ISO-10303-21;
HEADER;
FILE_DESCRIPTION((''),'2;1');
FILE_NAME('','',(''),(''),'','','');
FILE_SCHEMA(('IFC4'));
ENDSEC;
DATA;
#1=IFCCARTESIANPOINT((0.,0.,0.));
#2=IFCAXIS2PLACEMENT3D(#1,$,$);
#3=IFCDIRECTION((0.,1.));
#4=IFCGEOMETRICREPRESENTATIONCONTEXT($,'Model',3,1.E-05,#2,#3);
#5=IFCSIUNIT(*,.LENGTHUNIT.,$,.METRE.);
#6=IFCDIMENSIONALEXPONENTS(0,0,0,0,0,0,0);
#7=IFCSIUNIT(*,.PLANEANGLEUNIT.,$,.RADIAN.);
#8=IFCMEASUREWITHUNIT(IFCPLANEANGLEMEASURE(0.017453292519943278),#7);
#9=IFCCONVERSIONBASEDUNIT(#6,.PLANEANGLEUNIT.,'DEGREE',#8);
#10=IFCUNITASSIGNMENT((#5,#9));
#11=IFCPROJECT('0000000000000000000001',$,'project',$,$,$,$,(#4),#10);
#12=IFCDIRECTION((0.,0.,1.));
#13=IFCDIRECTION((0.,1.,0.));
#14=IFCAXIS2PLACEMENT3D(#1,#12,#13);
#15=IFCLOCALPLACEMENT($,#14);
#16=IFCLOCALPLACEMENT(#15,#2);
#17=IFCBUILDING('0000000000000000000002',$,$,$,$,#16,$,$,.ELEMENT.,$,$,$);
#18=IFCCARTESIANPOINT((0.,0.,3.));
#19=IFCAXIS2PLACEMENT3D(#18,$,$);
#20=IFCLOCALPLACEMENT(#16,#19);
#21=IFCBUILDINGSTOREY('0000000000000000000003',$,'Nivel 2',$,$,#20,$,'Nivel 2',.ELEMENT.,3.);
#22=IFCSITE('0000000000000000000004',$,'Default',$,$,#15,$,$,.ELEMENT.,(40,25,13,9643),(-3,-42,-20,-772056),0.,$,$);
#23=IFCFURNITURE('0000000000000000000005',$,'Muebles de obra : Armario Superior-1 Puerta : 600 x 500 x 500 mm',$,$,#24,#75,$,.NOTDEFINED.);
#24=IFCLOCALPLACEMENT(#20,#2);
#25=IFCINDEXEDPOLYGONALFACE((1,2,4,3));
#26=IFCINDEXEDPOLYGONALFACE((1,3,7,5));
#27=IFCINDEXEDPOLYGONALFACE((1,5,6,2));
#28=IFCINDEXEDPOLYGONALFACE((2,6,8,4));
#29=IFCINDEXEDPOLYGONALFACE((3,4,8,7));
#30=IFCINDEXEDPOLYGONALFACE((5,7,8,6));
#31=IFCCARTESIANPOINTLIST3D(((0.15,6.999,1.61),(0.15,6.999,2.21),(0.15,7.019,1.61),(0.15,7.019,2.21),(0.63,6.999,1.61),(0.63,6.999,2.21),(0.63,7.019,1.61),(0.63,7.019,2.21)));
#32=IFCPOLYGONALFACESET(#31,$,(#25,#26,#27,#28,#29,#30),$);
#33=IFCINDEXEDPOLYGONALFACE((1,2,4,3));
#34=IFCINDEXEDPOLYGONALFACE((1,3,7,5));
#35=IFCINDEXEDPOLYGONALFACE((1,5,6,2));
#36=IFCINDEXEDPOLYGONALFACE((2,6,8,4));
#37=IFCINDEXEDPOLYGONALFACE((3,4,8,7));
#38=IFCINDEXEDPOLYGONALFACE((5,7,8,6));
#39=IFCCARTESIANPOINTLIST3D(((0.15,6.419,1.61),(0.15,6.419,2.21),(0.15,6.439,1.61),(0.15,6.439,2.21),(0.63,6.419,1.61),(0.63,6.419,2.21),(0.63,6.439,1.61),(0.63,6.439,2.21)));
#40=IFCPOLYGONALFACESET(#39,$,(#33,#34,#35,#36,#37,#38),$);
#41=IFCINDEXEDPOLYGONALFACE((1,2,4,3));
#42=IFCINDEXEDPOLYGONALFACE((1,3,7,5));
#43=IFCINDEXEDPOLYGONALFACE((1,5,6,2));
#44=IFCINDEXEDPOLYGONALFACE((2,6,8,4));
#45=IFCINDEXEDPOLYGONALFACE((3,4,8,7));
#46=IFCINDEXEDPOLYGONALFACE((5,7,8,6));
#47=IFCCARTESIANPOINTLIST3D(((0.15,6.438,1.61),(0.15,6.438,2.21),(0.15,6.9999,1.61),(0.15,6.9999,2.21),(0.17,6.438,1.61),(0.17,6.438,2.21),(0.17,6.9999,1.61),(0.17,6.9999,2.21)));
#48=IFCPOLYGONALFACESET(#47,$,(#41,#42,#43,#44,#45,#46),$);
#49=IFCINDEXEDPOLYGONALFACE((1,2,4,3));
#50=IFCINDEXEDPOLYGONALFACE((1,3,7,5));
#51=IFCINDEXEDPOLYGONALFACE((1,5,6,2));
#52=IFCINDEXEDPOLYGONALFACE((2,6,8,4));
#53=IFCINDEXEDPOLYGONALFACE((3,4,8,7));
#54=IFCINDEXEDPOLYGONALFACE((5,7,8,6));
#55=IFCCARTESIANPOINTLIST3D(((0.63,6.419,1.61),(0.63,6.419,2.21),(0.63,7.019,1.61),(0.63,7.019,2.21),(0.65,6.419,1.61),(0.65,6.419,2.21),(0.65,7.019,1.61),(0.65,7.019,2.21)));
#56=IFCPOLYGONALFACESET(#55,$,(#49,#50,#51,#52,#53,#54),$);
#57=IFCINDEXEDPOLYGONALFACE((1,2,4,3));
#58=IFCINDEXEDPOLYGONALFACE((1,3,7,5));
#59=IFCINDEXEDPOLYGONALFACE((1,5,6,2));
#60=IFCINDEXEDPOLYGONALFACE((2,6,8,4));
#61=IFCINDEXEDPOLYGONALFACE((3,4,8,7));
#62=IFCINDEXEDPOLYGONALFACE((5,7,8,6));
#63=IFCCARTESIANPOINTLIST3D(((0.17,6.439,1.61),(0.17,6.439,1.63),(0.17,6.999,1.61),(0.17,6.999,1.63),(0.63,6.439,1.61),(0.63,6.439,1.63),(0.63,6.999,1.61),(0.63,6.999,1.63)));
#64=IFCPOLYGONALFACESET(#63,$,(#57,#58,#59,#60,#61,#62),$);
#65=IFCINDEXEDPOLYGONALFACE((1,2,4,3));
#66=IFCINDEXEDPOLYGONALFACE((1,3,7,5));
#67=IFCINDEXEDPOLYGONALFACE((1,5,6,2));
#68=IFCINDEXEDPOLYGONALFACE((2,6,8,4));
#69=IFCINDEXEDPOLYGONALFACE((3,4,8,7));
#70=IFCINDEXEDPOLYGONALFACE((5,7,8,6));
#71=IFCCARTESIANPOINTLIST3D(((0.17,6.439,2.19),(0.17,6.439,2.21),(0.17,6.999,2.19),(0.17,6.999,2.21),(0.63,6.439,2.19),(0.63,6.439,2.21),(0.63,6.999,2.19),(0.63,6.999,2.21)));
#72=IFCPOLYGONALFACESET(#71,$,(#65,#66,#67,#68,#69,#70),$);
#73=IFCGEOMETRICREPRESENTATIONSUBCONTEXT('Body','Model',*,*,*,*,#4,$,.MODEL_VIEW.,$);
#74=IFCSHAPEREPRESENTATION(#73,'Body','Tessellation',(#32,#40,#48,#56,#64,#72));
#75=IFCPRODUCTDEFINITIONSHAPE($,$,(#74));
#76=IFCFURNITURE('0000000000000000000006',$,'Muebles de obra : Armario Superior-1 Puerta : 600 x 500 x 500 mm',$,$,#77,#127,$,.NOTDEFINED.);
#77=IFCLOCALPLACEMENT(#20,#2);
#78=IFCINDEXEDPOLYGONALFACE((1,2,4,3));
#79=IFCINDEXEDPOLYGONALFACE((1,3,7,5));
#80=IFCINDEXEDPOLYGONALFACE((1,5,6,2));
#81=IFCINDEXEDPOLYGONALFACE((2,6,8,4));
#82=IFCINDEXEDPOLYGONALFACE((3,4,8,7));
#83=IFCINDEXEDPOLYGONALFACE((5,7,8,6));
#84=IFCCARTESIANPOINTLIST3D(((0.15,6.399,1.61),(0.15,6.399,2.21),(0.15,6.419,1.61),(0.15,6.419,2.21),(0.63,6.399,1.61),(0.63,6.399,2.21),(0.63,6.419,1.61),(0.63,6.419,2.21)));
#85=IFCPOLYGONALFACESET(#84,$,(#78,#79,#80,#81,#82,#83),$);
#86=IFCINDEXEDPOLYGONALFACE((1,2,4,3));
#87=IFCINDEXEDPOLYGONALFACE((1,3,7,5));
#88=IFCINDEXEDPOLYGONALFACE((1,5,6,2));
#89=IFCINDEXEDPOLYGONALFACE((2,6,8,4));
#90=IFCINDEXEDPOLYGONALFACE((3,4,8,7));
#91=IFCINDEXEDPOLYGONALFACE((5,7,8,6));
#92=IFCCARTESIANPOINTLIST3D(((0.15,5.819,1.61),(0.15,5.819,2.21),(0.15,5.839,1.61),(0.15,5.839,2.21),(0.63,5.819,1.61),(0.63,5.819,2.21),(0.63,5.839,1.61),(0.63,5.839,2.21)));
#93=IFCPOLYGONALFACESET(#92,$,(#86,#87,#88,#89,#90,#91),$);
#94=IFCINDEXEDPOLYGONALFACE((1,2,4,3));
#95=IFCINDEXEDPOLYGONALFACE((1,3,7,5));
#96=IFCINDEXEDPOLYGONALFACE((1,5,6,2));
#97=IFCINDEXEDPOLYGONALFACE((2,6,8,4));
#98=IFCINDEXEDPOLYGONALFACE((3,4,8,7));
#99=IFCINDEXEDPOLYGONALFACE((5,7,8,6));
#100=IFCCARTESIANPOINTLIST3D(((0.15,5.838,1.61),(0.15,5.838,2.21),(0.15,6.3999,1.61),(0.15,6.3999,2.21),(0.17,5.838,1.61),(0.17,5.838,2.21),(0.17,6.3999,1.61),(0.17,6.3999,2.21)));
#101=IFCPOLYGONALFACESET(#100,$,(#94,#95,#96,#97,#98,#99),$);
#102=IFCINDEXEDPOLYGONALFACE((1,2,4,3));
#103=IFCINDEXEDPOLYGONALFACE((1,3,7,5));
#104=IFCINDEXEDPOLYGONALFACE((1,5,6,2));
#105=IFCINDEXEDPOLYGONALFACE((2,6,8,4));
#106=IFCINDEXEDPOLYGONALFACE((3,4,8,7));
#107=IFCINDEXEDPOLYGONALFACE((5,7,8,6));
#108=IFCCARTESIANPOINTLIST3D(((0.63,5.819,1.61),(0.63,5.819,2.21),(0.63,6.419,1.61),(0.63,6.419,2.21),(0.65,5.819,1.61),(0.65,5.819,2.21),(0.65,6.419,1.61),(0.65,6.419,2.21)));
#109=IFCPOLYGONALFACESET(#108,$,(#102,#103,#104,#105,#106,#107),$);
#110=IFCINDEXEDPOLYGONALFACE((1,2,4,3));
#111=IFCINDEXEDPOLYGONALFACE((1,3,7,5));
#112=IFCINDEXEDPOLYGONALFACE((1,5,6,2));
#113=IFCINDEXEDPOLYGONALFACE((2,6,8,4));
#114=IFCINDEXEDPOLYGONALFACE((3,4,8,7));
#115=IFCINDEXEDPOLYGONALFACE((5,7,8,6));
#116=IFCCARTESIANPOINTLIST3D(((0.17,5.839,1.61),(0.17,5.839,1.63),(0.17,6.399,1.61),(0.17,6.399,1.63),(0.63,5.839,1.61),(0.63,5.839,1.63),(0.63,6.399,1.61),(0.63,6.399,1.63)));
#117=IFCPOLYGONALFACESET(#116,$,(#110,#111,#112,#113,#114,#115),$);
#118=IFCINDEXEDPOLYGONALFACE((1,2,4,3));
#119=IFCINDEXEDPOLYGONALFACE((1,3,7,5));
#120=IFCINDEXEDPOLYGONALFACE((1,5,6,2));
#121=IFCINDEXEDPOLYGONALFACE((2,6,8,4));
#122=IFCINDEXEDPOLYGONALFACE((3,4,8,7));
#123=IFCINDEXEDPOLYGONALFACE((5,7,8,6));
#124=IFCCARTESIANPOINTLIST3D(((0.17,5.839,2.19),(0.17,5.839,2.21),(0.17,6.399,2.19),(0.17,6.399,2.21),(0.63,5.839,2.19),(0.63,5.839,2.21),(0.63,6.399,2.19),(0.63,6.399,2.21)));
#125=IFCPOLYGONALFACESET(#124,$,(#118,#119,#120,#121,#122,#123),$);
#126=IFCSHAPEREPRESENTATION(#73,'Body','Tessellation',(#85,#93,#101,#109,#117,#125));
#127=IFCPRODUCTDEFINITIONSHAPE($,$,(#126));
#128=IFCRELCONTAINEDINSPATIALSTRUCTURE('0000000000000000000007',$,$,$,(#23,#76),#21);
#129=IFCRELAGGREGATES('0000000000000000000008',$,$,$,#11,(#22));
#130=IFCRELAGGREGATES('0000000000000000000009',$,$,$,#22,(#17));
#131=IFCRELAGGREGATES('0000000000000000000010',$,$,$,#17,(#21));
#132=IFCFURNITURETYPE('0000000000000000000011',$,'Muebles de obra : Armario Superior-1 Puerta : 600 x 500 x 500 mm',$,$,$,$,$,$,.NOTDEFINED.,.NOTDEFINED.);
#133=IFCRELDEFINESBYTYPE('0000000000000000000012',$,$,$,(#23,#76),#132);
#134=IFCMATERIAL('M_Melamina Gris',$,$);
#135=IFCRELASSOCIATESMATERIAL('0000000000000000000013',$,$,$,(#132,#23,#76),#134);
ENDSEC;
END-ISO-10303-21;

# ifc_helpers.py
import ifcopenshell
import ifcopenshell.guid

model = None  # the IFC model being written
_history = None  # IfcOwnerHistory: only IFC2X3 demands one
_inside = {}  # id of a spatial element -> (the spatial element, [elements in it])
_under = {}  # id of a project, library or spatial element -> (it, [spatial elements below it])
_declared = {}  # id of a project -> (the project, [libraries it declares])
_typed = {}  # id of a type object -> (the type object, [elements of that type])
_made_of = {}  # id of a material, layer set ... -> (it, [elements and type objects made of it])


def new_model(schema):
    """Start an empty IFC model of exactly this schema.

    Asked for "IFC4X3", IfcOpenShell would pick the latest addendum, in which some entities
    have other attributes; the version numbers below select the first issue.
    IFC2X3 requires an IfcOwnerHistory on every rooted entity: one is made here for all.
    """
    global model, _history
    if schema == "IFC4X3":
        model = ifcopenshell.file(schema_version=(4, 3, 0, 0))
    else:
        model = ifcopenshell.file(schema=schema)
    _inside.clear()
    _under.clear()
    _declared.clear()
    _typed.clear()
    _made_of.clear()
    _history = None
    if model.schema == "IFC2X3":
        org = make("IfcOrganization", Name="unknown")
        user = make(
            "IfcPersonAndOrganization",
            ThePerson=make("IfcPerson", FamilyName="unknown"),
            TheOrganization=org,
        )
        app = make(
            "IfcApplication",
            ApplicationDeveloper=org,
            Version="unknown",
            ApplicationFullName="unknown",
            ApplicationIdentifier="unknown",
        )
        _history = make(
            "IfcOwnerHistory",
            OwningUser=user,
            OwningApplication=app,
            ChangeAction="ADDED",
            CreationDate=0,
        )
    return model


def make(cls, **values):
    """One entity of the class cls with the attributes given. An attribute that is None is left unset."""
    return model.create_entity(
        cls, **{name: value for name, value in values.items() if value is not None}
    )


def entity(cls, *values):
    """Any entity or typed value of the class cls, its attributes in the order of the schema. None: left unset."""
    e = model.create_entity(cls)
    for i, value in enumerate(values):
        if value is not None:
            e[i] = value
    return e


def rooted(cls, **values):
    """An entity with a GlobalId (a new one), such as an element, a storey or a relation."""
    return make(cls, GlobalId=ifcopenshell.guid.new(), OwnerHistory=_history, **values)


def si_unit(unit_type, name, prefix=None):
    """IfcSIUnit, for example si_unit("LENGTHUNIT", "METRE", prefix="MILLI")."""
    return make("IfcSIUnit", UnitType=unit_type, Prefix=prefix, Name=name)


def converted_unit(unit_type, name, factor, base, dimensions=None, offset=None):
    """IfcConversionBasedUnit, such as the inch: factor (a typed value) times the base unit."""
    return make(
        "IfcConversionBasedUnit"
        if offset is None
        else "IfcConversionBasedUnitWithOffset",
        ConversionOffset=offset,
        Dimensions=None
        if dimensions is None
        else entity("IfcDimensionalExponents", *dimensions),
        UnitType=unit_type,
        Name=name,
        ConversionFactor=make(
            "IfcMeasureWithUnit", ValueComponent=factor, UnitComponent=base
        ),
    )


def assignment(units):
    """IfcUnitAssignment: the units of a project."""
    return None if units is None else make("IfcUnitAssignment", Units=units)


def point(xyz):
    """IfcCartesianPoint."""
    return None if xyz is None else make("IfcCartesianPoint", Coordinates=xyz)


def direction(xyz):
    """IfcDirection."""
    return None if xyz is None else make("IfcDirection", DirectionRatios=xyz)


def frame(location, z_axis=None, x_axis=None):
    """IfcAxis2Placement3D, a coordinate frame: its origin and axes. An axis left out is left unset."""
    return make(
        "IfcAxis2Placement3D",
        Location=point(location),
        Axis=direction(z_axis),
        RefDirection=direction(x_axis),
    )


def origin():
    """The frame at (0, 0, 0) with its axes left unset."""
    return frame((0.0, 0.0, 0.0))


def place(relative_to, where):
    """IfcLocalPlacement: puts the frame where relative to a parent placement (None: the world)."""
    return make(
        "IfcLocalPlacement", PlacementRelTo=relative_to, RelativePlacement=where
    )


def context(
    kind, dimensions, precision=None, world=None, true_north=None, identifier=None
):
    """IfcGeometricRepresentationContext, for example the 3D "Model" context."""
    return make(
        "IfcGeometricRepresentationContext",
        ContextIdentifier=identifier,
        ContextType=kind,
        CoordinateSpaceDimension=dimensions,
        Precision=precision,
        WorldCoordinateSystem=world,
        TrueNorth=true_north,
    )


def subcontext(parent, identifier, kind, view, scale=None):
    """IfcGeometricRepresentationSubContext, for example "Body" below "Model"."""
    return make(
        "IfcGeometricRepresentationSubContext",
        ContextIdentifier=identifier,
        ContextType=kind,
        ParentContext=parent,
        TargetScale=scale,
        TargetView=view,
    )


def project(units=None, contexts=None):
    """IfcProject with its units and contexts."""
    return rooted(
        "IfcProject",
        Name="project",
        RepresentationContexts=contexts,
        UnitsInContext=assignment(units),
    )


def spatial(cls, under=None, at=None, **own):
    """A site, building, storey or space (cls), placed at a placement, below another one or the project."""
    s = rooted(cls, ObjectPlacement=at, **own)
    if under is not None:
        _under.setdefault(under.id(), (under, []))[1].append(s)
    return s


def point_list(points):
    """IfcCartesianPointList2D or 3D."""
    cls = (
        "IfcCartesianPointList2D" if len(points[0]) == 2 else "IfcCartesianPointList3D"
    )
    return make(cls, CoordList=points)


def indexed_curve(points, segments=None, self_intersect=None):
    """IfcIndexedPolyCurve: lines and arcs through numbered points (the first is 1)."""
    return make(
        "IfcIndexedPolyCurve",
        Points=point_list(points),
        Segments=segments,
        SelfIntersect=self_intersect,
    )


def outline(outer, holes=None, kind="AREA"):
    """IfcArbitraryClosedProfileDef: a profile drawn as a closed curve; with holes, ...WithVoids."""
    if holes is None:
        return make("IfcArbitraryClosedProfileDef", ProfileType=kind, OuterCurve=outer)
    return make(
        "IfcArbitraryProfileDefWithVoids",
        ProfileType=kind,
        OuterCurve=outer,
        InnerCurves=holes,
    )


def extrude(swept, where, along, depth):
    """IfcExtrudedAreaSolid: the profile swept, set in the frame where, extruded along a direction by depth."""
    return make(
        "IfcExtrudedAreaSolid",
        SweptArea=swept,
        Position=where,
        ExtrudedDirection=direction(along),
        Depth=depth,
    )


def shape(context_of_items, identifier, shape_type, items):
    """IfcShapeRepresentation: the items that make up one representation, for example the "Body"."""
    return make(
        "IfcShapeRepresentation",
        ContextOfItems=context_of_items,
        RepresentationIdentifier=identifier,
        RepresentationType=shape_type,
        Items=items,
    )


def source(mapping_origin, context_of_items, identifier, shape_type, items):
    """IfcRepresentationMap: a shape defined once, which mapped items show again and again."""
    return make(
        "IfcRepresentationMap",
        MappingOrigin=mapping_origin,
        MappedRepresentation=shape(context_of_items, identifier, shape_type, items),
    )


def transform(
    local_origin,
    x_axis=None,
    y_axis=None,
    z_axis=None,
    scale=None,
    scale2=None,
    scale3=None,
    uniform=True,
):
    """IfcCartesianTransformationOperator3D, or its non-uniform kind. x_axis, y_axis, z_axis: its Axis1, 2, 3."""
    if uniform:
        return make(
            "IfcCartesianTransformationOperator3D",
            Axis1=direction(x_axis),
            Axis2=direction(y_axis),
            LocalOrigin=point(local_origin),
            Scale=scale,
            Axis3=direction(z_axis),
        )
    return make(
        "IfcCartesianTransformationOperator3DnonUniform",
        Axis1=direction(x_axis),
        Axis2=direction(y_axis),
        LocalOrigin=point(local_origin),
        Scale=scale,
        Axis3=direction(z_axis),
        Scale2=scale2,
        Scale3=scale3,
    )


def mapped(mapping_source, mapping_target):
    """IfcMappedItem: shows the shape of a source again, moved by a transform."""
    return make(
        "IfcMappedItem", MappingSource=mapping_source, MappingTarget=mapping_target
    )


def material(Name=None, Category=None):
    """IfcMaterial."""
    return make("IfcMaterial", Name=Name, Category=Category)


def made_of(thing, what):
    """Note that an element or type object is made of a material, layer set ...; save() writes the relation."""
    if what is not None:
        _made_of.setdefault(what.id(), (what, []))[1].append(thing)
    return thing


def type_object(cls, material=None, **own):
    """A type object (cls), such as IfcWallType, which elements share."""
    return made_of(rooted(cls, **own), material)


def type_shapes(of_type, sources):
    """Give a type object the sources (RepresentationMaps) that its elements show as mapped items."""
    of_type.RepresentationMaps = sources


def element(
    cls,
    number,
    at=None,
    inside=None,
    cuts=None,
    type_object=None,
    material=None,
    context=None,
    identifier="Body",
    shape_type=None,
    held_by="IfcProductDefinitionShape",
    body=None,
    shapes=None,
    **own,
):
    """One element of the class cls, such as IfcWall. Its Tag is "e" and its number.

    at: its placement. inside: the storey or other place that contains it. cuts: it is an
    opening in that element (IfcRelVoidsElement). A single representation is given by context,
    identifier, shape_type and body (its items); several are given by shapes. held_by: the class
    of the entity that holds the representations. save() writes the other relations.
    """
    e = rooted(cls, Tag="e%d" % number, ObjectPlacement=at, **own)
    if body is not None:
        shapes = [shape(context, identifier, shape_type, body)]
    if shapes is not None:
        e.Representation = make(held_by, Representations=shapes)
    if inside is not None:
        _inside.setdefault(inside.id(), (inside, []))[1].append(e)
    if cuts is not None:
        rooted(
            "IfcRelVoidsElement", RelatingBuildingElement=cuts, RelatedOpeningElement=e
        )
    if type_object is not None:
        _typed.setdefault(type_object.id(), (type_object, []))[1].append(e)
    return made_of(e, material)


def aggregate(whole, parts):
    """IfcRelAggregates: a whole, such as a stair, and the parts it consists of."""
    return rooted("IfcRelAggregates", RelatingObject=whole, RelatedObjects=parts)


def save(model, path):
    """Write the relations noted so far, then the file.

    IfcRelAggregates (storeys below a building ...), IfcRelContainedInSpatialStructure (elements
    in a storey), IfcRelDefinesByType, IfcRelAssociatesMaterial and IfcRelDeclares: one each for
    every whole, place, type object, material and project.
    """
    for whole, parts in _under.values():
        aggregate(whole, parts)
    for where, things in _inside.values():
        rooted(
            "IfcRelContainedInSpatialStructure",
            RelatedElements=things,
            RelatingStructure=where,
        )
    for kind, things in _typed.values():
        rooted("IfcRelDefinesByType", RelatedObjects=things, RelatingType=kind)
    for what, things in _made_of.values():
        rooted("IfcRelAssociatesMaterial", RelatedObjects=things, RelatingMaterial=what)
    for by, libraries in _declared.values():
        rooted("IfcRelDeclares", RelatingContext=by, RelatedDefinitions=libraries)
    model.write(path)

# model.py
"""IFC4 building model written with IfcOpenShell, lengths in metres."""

from ifc_helpers import new_model, entity, si_unit, converted_unit, direction, frame, origin, place, context, subcontext, project, spatial, indexed_curve, outline, extrude, source, transform, mapped, material, type_object, type_shapes, element, save


model = new_model("IFC4")

# Units and contexts
model_context = context("Model", 3, precision=1e-05, world=origin(), true_north=direction((0.0, 1.0)))
body_context = subcontext(model_context, "Body", "Model", "MODEL_VIEW")
ifc_project = project(units=[si_unit("LENGTHUNIT", "METRE"), converted_unit("PLANEANGLEUNIT", "DEGREE", entity("IfcPlaneAngleMeasure", 0.017453292519943278), si_unit("PLANEANGLEUNIT", "RADIAN"), dimensions=[0, 0, 0, 0, 0, 0, 0])], contexts=[model_context])

# Site, building, storey
site_placement = place(None, frame((0.0, 0.0, 0.0), z_axis=(0.0, 0.0, 1.0), x_axis=(0.0, 1.0, 0.0)))
site = spatial("IfcSite", under=ifc_project, at=site_placement, Name="Default", CompositionType="ELEMENT", RefLatitude=(40, 25, 13, 9643), RefLongitude=(-3, -42, -20, -772056), RefElevation=0.0)
building_placement = place(site_placement, origin())
building = spatial("IfcBuilding", under=site, at=building_placement, CompositionType="ELEMENT")
storey_placement = place(building_placement, frame((0.0, 0.0, 3.0)))
storey = spatial("IfcBuildingStorey", under=building, at=storey_placement, Name="Nivel 2", LongName="Nivel 2", CompositionType="ELEMENT", Elevation=3.0)

# Furniture
ifc_material_1 = material(Name="M_Melamina Gris")
furniture_type = type_object("IfcFurnitureType", Name="Muebles de obra : Armario Superior-1 Puerta : 600 x 500 x 500 mm", AssemblyPlace="NOTDEFINED", PredefinedType="NOTDEFINED", material=ifc_material_1)
shared_shape_1 = source(origin(), body_context, "Body", "SweptSolid", [
    extrude(outline(indexed_curve([(-0.01, -0.24), (0.01, -0.24), (0.01, 0.24), (-0.01, 0.24), (-0.01, -0.24)], self_intersect=False)), frame((-0.4213, 0.24, 0.0), z_axis=(0.0, 0.0, 1.0), x_axis=(-1.0, 0.0, 0.0)), (0.0, 0.0, 1.0), 0.6),
    extrude(outline(indexed_curve([(-0.24, -0.01), (0.24, -0.01), (0.24, 0.01), (-0.24, 0.01), (-0.24, -0.01)], self_intersect=False)), frame((0.1587, 0.24, 0.0), z_axis=(0.0, 0.0, 1.0), x_axis=(0.0, -1.0, 0.0)), (0.0, 0.0, 1.0), 0.6),
    extrude(outline(indexed_curve([(-0.281, -0.01), (0.281, -0.01), (0.281, 0.01), (-0.281, 0.01), (-0.281, -0.01)], self_intersect=False)), frame((-0.1313, 0.01, 0.0)), (0.0, 0.0, 1.0), 0.6),
    extrude(outline(indexed_curve([(-0.3, -0.01), (0.3, -0.01), (0.3, 0.01), (-0.3, 0.01), (-0.3, -0.01)], self_intersect=False)), frame((-0.1313, 0.49, 0.0)), (0.0, 0.0, 1.0), 0.6),
    extrude(outline(indexed_curve([(-0.23, -0.28), (0.23, -0.28), (0.23, 0.28), (-0.23, 0.28), (-0.23, -0.28)], self_intersect=False)), frame((-0.1313, 0.25, 0.0), z_axis=(0.0, 0.0, 1.0), x_axis=(0.0, 1.0, 0.0)), (0.0, 0.0, 1.0), 0.02),
    extrude(outline(indexed_curve([(-0.23, -0.28), (0.23, -0.28), (0.23, 0.28), (-0.23, 0.28), (-0.23, -0.28)], self_intersect=False)), frame((-0.1313, 0.25, 0.58), z_axis=(0.0, 0.0, 1.0), x_axis=(0.0, 1.0, 0.0)), (0.0, 0.0, 1.0), 0.02),
])
type_shapes(furniture_type, [shared_shape_1])
for number, where, z_axis, x_axis, name in (
    (1, (0.15, 6.5877, 1.61), (0.0, 0.0, 1.0), (0.0, -1.0, 0.0), "Muebles de obra : Armario Superior-1 Puerta : 600 x 500 x 500 mm"),
    (2, (0.15, 5.9877, 1.61), (0.0, 0.0, 1.0), (0.0, -1.0, 0.0), "Muebles de obra : Armario Superior-1 Puerta : 600 x 500 x 500 mm"),
):
    element("IfcFurniture", number, at=place(storey_placement, frame(where, z_axis=z_axis, x_axis=x_axis)), inside=storey, type_object=furniture_type, material=ifc_material_1, Name=name, PredefinedType="NOTDEFINED", context=body_context, shape_type="MappedRepresentation", body=[
        mapped(shared_shape_1, transform((0.0, 0.0, 0.0), scale=1.0)),
    ])

save(model, "model.ifc")
